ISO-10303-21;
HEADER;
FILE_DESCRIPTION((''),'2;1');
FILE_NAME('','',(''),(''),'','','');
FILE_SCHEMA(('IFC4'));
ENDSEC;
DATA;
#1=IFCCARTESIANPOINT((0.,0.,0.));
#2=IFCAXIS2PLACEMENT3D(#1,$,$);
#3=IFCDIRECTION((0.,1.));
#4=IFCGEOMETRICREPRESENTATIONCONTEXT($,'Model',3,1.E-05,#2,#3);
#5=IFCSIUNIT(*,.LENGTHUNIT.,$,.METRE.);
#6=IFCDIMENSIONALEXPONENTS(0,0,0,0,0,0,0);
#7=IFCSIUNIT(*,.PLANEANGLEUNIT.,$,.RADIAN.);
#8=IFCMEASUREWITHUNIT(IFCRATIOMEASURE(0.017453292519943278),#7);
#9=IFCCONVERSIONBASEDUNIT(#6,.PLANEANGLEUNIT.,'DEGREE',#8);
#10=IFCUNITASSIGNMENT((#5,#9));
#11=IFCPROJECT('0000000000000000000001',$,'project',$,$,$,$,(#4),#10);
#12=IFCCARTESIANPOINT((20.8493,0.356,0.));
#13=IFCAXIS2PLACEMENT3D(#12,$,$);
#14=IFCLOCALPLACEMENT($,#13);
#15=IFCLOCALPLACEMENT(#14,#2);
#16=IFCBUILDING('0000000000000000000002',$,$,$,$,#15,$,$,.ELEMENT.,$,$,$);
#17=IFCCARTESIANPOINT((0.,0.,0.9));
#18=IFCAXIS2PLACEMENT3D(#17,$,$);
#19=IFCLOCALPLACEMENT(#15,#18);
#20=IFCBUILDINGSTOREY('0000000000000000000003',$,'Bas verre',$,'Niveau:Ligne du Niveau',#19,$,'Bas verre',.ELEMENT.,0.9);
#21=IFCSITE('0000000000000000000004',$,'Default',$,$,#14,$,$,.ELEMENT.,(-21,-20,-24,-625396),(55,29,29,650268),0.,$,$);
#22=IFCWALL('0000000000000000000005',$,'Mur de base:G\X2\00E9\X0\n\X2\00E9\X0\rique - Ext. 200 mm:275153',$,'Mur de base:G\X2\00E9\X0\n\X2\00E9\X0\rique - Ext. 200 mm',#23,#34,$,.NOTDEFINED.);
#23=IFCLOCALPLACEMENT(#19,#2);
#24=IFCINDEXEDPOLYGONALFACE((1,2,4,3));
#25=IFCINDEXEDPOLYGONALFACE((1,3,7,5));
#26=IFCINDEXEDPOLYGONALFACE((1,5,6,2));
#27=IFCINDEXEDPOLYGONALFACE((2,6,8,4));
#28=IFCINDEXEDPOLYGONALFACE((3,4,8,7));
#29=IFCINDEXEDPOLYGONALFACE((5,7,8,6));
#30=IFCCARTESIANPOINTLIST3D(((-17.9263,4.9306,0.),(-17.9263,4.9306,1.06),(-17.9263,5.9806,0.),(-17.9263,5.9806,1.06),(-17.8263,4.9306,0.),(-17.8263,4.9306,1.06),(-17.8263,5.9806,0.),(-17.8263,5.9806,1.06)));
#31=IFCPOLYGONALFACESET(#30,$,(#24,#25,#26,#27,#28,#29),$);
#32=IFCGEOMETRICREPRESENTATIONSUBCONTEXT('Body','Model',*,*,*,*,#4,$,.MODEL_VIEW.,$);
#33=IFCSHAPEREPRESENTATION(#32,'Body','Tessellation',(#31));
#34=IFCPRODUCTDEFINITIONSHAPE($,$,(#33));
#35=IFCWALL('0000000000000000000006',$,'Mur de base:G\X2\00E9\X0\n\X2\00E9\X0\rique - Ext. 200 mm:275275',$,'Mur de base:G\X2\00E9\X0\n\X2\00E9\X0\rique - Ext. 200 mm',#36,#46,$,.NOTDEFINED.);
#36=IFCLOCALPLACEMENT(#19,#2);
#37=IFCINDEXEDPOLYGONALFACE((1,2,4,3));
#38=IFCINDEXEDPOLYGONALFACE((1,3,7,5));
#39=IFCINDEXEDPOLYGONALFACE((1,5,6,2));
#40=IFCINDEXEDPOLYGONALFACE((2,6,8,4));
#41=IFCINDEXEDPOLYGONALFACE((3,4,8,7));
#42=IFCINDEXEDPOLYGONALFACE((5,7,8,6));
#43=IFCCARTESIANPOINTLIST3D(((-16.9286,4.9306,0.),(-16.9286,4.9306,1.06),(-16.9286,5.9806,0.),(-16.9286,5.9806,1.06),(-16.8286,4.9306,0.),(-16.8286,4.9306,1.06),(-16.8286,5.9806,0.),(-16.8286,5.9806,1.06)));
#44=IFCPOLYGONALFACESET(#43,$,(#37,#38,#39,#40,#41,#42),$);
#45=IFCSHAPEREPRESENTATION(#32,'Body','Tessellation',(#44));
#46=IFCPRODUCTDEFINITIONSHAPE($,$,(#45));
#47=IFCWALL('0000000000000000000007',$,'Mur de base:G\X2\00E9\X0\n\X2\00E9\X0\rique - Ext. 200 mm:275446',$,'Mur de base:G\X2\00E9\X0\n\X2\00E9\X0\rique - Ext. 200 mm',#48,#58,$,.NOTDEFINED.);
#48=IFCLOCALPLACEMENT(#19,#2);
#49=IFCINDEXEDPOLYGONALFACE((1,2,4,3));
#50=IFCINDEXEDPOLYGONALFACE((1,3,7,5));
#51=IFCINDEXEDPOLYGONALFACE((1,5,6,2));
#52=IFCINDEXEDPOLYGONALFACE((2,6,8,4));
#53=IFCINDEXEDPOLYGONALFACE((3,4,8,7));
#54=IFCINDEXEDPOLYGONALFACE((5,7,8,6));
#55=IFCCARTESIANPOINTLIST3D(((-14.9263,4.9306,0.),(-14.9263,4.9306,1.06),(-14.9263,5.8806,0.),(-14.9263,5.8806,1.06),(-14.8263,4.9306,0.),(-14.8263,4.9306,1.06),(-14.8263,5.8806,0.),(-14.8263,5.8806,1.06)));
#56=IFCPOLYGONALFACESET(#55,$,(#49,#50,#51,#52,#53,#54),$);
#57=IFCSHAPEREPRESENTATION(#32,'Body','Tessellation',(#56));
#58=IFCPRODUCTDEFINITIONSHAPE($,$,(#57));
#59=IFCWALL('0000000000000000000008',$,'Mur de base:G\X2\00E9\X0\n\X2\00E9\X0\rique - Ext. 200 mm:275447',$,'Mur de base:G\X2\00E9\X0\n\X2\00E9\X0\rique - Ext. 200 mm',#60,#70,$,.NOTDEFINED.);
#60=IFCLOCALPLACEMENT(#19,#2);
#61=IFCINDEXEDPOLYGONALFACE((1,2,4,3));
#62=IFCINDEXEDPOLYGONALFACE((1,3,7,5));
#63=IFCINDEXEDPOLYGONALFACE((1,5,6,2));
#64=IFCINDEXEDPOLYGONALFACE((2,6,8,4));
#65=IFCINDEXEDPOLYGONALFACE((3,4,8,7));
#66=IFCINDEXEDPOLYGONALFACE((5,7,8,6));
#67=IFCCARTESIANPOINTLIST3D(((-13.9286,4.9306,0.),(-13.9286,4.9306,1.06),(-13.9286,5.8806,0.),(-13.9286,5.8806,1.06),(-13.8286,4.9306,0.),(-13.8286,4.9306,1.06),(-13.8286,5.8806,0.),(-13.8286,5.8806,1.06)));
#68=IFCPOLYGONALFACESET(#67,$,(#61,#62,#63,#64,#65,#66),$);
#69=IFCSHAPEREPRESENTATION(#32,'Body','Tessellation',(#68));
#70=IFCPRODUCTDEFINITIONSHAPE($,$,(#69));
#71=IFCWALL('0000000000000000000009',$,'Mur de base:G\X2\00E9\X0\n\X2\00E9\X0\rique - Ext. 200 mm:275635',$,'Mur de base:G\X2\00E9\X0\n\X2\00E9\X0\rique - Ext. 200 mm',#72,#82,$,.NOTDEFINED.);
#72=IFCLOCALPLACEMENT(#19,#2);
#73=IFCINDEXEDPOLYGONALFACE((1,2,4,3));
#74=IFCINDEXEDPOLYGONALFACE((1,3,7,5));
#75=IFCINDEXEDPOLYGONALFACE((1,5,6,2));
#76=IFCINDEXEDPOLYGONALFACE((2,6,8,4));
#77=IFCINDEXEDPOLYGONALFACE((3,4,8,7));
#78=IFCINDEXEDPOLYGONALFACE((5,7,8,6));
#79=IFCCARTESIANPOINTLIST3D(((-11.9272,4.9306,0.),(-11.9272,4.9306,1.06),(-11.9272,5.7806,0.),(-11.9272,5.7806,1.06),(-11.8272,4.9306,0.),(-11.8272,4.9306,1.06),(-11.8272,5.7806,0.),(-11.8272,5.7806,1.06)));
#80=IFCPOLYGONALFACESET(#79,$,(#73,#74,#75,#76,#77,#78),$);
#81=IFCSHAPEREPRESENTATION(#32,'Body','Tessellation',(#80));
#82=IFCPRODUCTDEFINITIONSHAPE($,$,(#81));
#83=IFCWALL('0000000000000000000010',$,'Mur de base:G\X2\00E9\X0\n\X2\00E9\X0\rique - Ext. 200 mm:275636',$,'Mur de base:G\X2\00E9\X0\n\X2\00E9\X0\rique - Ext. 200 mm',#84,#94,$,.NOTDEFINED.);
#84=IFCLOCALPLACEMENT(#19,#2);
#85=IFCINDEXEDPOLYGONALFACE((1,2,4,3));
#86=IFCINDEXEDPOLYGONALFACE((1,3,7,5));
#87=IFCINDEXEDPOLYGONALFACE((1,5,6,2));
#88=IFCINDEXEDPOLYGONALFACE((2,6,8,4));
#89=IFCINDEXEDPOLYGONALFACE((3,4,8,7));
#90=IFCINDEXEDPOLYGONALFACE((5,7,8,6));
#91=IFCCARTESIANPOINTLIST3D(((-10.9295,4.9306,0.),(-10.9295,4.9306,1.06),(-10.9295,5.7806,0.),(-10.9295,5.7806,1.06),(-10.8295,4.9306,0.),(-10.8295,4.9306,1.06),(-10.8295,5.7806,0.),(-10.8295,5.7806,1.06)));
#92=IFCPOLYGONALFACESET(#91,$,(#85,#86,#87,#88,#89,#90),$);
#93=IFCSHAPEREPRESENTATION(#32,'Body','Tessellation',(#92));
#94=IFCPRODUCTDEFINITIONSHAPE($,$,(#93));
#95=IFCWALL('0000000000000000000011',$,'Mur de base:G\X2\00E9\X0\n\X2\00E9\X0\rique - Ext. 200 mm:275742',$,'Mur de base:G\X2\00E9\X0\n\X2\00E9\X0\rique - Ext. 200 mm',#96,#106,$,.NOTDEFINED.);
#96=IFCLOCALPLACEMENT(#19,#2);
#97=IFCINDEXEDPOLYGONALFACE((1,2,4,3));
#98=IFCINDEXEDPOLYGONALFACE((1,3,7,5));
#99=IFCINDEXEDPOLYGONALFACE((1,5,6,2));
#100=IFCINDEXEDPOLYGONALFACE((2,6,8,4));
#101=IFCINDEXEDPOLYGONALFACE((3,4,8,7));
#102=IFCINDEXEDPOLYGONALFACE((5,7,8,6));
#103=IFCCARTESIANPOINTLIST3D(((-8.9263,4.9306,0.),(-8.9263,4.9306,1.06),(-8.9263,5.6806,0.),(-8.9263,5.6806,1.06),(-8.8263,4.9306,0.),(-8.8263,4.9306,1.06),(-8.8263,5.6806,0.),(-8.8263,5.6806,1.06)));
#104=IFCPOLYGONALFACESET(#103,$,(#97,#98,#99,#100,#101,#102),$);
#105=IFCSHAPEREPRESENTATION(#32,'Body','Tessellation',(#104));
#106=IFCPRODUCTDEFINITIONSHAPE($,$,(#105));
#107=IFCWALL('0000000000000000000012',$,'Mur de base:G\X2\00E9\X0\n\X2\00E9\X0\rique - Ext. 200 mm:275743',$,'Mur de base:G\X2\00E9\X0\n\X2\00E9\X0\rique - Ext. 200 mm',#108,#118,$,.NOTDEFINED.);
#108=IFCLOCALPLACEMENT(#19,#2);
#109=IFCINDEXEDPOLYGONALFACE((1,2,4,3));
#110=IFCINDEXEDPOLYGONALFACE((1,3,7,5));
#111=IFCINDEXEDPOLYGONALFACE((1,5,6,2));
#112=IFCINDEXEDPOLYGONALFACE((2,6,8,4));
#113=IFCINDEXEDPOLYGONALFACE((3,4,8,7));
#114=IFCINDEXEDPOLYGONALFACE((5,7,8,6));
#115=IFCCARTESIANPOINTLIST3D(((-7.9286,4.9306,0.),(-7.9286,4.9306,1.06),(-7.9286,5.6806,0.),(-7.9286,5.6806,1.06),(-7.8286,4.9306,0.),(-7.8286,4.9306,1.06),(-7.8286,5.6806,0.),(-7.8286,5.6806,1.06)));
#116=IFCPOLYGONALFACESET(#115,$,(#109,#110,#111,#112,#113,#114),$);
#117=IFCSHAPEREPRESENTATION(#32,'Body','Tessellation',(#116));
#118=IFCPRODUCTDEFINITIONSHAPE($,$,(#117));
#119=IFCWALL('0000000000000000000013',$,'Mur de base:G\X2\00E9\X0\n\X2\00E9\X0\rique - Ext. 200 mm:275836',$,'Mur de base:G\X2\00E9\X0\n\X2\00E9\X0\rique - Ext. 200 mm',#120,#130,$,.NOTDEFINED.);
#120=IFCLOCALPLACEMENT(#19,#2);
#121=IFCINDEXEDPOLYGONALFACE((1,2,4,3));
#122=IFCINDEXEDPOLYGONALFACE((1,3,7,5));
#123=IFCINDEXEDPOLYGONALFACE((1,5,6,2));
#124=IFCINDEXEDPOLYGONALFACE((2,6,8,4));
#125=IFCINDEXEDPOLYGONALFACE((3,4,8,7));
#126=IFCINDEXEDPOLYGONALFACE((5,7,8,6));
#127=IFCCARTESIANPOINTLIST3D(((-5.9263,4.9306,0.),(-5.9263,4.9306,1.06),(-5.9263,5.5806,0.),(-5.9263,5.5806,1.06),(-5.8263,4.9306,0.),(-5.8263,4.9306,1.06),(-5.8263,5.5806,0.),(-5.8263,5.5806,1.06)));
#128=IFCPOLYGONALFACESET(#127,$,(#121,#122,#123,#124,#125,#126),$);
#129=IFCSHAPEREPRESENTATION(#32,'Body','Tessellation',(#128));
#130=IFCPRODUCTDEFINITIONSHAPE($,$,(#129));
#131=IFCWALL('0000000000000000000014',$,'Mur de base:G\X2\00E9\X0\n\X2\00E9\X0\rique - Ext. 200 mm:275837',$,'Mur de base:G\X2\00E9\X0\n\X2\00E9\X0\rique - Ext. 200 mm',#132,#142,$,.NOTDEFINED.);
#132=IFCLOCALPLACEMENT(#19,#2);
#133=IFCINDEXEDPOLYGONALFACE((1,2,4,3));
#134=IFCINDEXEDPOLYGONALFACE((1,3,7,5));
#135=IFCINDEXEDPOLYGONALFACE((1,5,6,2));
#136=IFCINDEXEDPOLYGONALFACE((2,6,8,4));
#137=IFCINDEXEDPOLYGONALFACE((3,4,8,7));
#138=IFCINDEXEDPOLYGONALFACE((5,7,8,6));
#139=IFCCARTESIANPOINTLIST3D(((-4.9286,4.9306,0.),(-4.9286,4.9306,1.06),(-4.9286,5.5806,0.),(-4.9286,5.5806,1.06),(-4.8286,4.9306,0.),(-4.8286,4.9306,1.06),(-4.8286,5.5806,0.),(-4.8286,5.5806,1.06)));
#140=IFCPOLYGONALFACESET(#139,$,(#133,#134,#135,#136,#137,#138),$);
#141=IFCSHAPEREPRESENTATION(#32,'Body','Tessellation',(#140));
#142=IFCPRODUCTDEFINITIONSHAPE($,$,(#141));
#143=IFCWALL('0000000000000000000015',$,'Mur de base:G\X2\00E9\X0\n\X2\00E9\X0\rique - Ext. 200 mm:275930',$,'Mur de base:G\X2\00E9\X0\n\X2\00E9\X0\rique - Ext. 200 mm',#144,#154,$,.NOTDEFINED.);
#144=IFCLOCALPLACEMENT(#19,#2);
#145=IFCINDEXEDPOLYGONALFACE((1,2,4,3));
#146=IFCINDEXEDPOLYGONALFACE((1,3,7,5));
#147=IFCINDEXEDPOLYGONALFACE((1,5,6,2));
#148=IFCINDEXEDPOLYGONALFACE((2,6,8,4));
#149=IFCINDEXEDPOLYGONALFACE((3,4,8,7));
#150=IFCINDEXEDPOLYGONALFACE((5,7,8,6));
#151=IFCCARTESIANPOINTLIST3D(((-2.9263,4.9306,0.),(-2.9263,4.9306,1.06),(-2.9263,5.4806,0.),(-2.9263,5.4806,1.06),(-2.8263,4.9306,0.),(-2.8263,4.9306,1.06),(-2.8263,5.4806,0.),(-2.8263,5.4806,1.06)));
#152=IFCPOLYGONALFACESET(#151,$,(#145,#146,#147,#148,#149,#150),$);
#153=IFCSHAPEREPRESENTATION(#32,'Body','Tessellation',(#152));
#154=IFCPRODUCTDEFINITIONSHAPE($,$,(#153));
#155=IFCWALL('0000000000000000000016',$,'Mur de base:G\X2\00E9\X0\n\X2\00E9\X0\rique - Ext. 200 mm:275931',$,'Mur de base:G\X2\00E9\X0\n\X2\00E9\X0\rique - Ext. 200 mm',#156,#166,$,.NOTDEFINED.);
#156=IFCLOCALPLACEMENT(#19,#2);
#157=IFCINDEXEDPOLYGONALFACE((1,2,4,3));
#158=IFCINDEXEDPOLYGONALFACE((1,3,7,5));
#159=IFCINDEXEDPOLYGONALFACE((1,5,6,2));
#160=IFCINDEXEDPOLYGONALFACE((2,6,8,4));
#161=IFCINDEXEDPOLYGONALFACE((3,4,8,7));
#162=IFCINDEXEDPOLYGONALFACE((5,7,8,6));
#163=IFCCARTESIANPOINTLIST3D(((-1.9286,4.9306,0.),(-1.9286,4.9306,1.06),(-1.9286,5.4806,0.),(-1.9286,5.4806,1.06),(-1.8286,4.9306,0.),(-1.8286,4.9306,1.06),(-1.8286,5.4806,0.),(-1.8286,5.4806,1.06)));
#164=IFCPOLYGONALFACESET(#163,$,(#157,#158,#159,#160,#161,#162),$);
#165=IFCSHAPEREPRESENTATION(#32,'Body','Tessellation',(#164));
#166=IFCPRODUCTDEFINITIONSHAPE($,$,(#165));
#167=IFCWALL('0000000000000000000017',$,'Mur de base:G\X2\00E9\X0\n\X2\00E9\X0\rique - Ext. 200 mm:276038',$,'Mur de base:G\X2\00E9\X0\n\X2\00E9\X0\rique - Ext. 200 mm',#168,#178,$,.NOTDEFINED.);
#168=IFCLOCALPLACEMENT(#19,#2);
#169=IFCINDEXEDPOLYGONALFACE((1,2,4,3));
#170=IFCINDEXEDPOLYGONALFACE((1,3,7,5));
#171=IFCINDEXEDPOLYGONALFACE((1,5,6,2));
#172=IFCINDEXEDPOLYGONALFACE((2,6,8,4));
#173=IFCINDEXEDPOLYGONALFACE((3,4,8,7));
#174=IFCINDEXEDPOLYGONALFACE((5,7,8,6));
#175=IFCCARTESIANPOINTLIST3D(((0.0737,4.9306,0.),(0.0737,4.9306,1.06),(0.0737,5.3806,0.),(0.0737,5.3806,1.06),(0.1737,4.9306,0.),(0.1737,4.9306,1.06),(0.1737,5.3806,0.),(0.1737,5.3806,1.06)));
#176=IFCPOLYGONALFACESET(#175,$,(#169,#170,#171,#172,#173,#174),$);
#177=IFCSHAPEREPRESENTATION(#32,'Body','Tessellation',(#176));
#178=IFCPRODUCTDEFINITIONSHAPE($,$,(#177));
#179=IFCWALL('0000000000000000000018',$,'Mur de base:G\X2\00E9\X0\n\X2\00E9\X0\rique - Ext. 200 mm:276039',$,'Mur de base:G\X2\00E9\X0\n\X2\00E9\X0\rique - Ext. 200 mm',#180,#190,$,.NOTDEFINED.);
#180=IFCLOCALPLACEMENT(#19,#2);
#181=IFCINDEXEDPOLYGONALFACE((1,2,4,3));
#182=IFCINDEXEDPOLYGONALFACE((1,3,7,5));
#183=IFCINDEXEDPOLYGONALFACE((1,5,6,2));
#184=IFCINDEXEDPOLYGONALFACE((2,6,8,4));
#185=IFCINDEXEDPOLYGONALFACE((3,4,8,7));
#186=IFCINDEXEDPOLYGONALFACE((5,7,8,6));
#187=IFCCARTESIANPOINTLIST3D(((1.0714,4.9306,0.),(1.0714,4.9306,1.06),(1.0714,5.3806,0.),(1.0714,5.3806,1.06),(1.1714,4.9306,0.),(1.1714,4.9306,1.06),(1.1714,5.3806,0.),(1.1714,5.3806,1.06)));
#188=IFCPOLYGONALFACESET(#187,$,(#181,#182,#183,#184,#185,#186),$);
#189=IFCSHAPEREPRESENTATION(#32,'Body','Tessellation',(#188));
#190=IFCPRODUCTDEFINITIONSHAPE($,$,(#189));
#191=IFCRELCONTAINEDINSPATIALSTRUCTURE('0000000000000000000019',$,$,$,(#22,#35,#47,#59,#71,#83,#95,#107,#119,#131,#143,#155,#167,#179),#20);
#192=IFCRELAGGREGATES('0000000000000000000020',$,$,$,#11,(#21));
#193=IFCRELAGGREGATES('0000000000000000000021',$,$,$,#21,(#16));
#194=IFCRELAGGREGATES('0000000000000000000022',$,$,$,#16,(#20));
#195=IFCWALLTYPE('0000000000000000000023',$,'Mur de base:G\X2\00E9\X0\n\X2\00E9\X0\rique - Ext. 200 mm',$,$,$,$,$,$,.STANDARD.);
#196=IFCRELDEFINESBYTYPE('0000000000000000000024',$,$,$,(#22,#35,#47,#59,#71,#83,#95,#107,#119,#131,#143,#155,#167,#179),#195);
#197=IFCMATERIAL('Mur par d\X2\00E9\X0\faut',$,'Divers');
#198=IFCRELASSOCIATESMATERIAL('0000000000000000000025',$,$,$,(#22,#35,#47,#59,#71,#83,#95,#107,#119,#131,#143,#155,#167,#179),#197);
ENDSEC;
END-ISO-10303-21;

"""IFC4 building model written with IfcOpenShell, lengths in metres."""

from ifc_helpers import new_model, entity, si_unit, converted_unit, direction, frame, origin, place, context, subcontext, project, spatial, indexed_curve, outline, extrude, material, type_object, element, save


model = new_model("IFC4")

# Units and contexts
model_context = context("Model", 3, precision=1e-05, world=origin(), true_north=direction((0.0, 1.0)))
body_context = subcontext(model_context, "Body", "Model", "MODEL_VIEW")
ifc_project = project(units=[si_unit("LENGTHUNIT", "METRE"), converted_unit("PLANEANGLEUNIT", "DEGREE", entity("IfcRatioMeasure", 0.017453292519943278), si_unit("PLANEANGLEUNIT", "RADIAN"), dimensions=[0, 0, 0, 0, 0, 0, 0])], contexts=[model_context])

# Site, building, storey
site_placement = place(None, frame((20.8493, 0.356, 0.0)))
site = spatial("IfcSite", under=ifc_project, at=site_placement, Name="Default", CompositionType="ELEMENT", RefLatitude=(-21, -20, -24, -625396), RefLongitude=(55, 29, 29, 650268), RefElevation=0.0)
building_placement = place(site_placement, origin())
building = spatial("IfcBuilding", under=site, at=building_placement, CompositionType="ELEMENT")
storey_placement = place(building_placement, frame((0.0, 0.0, 0.9)))
storey = spatial("IfcBuildingStorey", under=building, at=storey_placement, Name="Bas verre", ObjectType="Niveau:Ligne du Niveau", LongName="Bas verre", CompositionType="ELEMENT", Elevation=0.9)

# Walls
ifc_material = material(Name="Mur par défaut", Category="Divers")
wall_type = type_object("IfcWallType", Name="Mur de base:Générique - Ext. 200 mm", PredefinedType="STANDARD")
wall_1_placement = place(storey_placement, frame((-17.8763, 4.9306, 0.0), z_axis=(0.0, 0.0, 1.0), x_axis=(0.0, 1.0, 0.0)))
element("IfcWall", 1, at=wall_1_placement, inside=storey, type_object=wall_type, material=ifc_material, Name="Mur de base:Générique - Ext. 200 mm:275153", ObjectType="Mur de base:Générique - Ext. 200 mm", PredefinedType="NOTDEFINED", context=body_context, shape_type="SweptSolid", body=[
    extrude(outline(indexed_curve([(1.05, 0.05), (0.0, 0.05), (0.0, -0.05), (1.05, -0.05), (1.05, 0.05)], self_intersect=False)), origin(), (0.0, 0.0, 1.0), 1.06),
])
wall_2_placement = place(storey_placement, frame((-16.8786, 4.9306, 0.0), z_axis=(0.0, 0.0, 1.0), x_axis=(0.0, 1.0, 0.0)))
element("IfcWall", 2, at=wall_2_placement, inside=storey, type_object=wall_type, material=ifc_material, Name="Mur de base:Générique - Ext. 200 mm:275275", ObjectType="Mur de base:Générique - Ext. 200 mm", PredefinedType="NOTDEFINED", context=body_context, shape_type="SweptSolid", body=[
    extrude(outline(indexed_curve([(1.05, 0.05), (0.0, 0.05), (0.0, -0.05), (1.05, -0.05), (1.05, 0.05)], self_intersect=False)), origin(), (0.0, 0.0, 1.0), 1.06),
])
wall_3_placement = place(storey_placement, frame((-14.8763, 4.9306, 0.0), z_axis=(0.0, 0.0, 1.0), x_axis=(0.0, 1.0, 0.0)))
element("IfcWall", 3, at=wall_3_placement, inside=storey, type_object=wall_type, material=ifc_material, Name="Mur de base:Générique - Ext. 200 mm:275446", ObjectType="Mur de base:Générique - Ext. 200 mm", PredefinedType="NOTDEFINED", context=body_context, shape_type="SweptSolid", body=[
    extrude(outline(indexed_curve([(0.95, 0.05), (0.0, 0.05), (0.0, -0.05), (0.95, -0.05), (0.95, 0.05)], self_intersect=False)), origin(), (0.0, 0.0, 1.0), 1.06),
])
wall_4_placement = place(storey_placement, frame((-13.8786, 4.9306, 0.0), z_axis=(0.0, 0.0, 1.0), x_axis=(0.0, 1.0, 0.0)))
element("IfcWall", 4, at=wall_4_placement, inside=storey, type_object=wall_type, material=ifc_material, Name="Mur de base:Générique - Ext. 200 mm:275447", ObjectType="Mur de base:Générique - Ext. 200 mm", PredefinedType="NOTDEFINED", context=body_context, shape_type="SweptSolid", body=[
    extrude(outline(indexed_curve([(0.95, 0.05), (0.0, 0.05), (0.0, -0.05), (0.95, -0.05), (0.95, 0.05)], self_intersect=False)), origin(), (0.0, 0.0, 1.0), 1.06),
])
wall_5_placement = place(storey_placement, frame((-11.8772, 4.9306, 0.0), z_axis=(0.0, 0.0, 1.0), x_axis=(0.0, 1.0, 0.0)))
element("IfcWall", 5, at=wall_5_placement, inside=storey, type_object=wall_type, material=ifc_material, Name="Mur de base:Générique - Ext. 200 mm:275635", ObjectType="Mur de base:Générique - Ext. 200 mm", PredefinedType="NOTDEFINED", context=body_context, shape_type="SweptSolid", body=[
    extrude(outline(indexed_curve([(0.85, 0.05), (0.0, 0.05), (0.0, -0.05), (0.85, -0.05), (0.85, 0.05)], self_intersect=False)), origin(), (0.0, 0.0, 1.0), 1.06),
])
wall_6_placement = place(storey_placement, frame((-10.8795, 4.9306, 0.0), z_axis=(0.0, 0.0, 1.0), x_axis=(0.0, 1.0, 0.0)))
element("IfcWall", 6, at=wall_6_placement, inside=storey, type_object=wall_type, material=ifc_material, Name="Mur de base:Générique - Ext. 200 mm:275636", ObjectType="Mur de base:Générique - Ext. 200 mm", PredefinedType="NOTDEFINED", context=body_context, shape_type="SweptSolid", body=[
    extrude(outline(indexed_curve([(0.85, 0.05), (0.0, 0.05), (0.0, -0.05), (0.85, -0.05), (0.85, 0.05)], self_intersect=False)), origin(), (0.0, 0.0, 1.0), 1.06),
])
wall_7_placement = place(storey_placement, frame((-8.8763, 4.9306, 0.0), z_axis=(0.0, 0.0, 1.0), x_axis=(0.0, 1.0, 0.0)))
element("IfcWall", 7, at=wall_7_placement, inside=storey, type_object=wall_type, material=ifc_material, Name="Mur de base:Générique - Ext. 200 mm:275742", ObjectType="Mur de base:Générique - Ext. 200 mm", PredefinedType="NOTDEFINED", context=body_context, shape_type="SweptSolid", body=[
    extrude(outline(indexed_curve([(0.75, 0.05), (0.0, 0.05), (0.0, -0.05), (0.75, -0.05), (0.75, 0.05)], self_intersect=False)), origin(), (0.0, 0.0, 1.0), 1.06),
])
wall_8_placement = place(storey_placement, frame((-7.8786, 4.9306, 0.0), z_axis=(0.0, 0.0, 1.0), x_axis=(0.0, 1.0, 0.0)))
element("IfcWall", 8, at=wall_8_placement, inside=storey, type_object=wall_type, material=ifc_material, Name="Mur de base:Générique - Ext. 200 mm:275743", ObjectType="Mur de base:Générique - Ext. 200 mm", PredefinedType="NOTDEFINED", context=body_context, shape_type="SweptSolid", body=[
    extrude(outline(indexed_curve([(0.75, 0.05), (0.0, 0.05), (0.0, -0.05), (0.75, -0.05), (0.75, 0.05)], self_intersect=False)), origin(), (0.0, 0.0, 1.0), 1.06),
])
wall_9_placement = place(storey_placement, frame((-5.8763, 4.9306, 0.0), z_axis=(0.0, 0.0, 1.0), x_axis=(0.0, 1.0, 0.0)))
element("IfcWall", 9, at=wall_9_placement, inside=storey, type_object=wall_type, material=ifc_material, Name="Mur de base:Générique - Ext. 200 mm:275836", ObjectType="Mur de base:Générique - Ext. 200 mm", PredefinedType="NOTDEFINED", context=body_context, shape_type="SweptSolid", body=[
    extrude(outline(indexed_curve([(0.65, 0.05), (0.0, 0.05), (0.0, -0.05), (0.65, -0.05), (0.65, 0.05)], self_intersect=False)), origin(), (0.0, 0.0, 1.0), 1.06),
])
wall_10_placement = place(storey_placement, frame((-4.8786, 4.9306, 0.0), z_axis=(0.0, 0.0, 1.0), x_axis=(0.0, 1.0, 0.0)))
element("IfcWall", 10, at=wall_10_placement, inside=storey, type_object=wall_type, material=ifc_material, Name="Mur de base:Générique - Ext. 200 mm:275837", ObjectType="Mur de base:Générique - Ext. 200 mm", PredefinedType="NOTDEFINED", context=body_context, shape_type="SweptSolid", body=[
    extrude(outline(indexed_curve([(0.65, 0.05), (0.0, 0.05), (0.0, -0.05), (0.65, -0.05), (0.65, 0.05)], self_intersect=False)), origin(), (0.0, 0.0, 1.0), 1.06),
])
wall_11_placement = place(storey_placement, frame((-2.8763, 4.9306, 0.0), z_axis=(0.0, 0.0, 1.0), x_axis=(0.0, 1.0, 0.0)))
element("IfcWall", 11, at=wall_11_placement, inside=storey, type_object=wall_type, material=ifc_material, Name="Mur de base:Générique - Ext. 200 mm:275930", ObjectType="Mur de base:Générique - Ext. 200 mm", PredefinedType="NOTDEFINED", context=body_context, shape_type="SweptSolid", body=[
    extrude(outline(indexed_curve([(0.55, 0.05), (0.0, 0.05), (0.0, -0.05), (0.55, -0.05), (0.55, 0.05)], self_intersect=False)), origin(), (0.0, 0.0, 1.0), 1.06),
])
wall_12_placement = place(storey_placement, frame((-1.8786, 4.9306, 0.0), z_axis=(0.0, 0.0, 1.0), x_axis=(0.0, 1.0, 0.0)))
element("IfcWall", 12, at=wall_12_placement, inside=storey, type_object=wall_type, material=ifc_material, Name="Mur de base:Générique - Ext. 200 mm:275931", ObjectType="Mur de base:Générique - Ext. 200 mm", PredefinedType="NOTDEFINED", context=body_context, shape_type="SweptSolid", body=[
    extrude(outline(indexed_curve([(0.55, 0.05), (0.0, 0.05), (0.0, -0.05), (0.55, -0.05), (0.55, 0.05)], self_intersect=False)), origin(), (0.0, 0.0, 1.0), 1.06),
])
wall_13_placement = place(storey_placement, frame((0.1237, 4.9306, 0.0), z_axis=(0.0, 0.0, 1.0), x_axis=(0.0, 1.0, 0.0)))
element("IfcWall", 13, at=wall_13_placement, inside=storey, type_object=wall_type, material=ifc_material, Name="Mur de base:Générique - Ext. 200 mm:276038", ObjectType="Mur de base:Générique - Ext. 200 mm", PredefinedType="NOTDEFINED", context=body_context, shape_type="SweptSolid", body=[
    extrude(outline(indexed_curve([(0.45, 0.05), (0.0, 0.05), (0.0, -0.05), (0.45, -0.05), (0.45, 0.05)], self_intersect=False)), origin(), (0.0, 0.0, 1.0), 1.06),
])
wall_14_placement = place(storey_placement, frame((1.1214, 4.9306, 0.0), z_axis=(0.0, 0.0, 1.0), x_axis=(0.0, 1.0, 0.0)))
element("IfcWall", 14, at=wall_14_placement, inside=storey, type_object=wall_type, material=ifc_material, Name="Mur de base:Générique - Ext. 200 mm:276039", ObjectType="Mur de base:Générique - Ext. 200 mm", PredefinedType="NOTDEFINED", context=body_context, shape_type="SweptSolid", body=[
    extrude(outline(indexed_curve([(0.45, 0.05), (0.0, 0.05), (0.0, -0.05), (0.45, -0.05), (0.45, 0.05)], self_intersect=False)), origin(), (0.0, 0.0, 1.0), 1.06),
])

save(model, "model.ifc")
